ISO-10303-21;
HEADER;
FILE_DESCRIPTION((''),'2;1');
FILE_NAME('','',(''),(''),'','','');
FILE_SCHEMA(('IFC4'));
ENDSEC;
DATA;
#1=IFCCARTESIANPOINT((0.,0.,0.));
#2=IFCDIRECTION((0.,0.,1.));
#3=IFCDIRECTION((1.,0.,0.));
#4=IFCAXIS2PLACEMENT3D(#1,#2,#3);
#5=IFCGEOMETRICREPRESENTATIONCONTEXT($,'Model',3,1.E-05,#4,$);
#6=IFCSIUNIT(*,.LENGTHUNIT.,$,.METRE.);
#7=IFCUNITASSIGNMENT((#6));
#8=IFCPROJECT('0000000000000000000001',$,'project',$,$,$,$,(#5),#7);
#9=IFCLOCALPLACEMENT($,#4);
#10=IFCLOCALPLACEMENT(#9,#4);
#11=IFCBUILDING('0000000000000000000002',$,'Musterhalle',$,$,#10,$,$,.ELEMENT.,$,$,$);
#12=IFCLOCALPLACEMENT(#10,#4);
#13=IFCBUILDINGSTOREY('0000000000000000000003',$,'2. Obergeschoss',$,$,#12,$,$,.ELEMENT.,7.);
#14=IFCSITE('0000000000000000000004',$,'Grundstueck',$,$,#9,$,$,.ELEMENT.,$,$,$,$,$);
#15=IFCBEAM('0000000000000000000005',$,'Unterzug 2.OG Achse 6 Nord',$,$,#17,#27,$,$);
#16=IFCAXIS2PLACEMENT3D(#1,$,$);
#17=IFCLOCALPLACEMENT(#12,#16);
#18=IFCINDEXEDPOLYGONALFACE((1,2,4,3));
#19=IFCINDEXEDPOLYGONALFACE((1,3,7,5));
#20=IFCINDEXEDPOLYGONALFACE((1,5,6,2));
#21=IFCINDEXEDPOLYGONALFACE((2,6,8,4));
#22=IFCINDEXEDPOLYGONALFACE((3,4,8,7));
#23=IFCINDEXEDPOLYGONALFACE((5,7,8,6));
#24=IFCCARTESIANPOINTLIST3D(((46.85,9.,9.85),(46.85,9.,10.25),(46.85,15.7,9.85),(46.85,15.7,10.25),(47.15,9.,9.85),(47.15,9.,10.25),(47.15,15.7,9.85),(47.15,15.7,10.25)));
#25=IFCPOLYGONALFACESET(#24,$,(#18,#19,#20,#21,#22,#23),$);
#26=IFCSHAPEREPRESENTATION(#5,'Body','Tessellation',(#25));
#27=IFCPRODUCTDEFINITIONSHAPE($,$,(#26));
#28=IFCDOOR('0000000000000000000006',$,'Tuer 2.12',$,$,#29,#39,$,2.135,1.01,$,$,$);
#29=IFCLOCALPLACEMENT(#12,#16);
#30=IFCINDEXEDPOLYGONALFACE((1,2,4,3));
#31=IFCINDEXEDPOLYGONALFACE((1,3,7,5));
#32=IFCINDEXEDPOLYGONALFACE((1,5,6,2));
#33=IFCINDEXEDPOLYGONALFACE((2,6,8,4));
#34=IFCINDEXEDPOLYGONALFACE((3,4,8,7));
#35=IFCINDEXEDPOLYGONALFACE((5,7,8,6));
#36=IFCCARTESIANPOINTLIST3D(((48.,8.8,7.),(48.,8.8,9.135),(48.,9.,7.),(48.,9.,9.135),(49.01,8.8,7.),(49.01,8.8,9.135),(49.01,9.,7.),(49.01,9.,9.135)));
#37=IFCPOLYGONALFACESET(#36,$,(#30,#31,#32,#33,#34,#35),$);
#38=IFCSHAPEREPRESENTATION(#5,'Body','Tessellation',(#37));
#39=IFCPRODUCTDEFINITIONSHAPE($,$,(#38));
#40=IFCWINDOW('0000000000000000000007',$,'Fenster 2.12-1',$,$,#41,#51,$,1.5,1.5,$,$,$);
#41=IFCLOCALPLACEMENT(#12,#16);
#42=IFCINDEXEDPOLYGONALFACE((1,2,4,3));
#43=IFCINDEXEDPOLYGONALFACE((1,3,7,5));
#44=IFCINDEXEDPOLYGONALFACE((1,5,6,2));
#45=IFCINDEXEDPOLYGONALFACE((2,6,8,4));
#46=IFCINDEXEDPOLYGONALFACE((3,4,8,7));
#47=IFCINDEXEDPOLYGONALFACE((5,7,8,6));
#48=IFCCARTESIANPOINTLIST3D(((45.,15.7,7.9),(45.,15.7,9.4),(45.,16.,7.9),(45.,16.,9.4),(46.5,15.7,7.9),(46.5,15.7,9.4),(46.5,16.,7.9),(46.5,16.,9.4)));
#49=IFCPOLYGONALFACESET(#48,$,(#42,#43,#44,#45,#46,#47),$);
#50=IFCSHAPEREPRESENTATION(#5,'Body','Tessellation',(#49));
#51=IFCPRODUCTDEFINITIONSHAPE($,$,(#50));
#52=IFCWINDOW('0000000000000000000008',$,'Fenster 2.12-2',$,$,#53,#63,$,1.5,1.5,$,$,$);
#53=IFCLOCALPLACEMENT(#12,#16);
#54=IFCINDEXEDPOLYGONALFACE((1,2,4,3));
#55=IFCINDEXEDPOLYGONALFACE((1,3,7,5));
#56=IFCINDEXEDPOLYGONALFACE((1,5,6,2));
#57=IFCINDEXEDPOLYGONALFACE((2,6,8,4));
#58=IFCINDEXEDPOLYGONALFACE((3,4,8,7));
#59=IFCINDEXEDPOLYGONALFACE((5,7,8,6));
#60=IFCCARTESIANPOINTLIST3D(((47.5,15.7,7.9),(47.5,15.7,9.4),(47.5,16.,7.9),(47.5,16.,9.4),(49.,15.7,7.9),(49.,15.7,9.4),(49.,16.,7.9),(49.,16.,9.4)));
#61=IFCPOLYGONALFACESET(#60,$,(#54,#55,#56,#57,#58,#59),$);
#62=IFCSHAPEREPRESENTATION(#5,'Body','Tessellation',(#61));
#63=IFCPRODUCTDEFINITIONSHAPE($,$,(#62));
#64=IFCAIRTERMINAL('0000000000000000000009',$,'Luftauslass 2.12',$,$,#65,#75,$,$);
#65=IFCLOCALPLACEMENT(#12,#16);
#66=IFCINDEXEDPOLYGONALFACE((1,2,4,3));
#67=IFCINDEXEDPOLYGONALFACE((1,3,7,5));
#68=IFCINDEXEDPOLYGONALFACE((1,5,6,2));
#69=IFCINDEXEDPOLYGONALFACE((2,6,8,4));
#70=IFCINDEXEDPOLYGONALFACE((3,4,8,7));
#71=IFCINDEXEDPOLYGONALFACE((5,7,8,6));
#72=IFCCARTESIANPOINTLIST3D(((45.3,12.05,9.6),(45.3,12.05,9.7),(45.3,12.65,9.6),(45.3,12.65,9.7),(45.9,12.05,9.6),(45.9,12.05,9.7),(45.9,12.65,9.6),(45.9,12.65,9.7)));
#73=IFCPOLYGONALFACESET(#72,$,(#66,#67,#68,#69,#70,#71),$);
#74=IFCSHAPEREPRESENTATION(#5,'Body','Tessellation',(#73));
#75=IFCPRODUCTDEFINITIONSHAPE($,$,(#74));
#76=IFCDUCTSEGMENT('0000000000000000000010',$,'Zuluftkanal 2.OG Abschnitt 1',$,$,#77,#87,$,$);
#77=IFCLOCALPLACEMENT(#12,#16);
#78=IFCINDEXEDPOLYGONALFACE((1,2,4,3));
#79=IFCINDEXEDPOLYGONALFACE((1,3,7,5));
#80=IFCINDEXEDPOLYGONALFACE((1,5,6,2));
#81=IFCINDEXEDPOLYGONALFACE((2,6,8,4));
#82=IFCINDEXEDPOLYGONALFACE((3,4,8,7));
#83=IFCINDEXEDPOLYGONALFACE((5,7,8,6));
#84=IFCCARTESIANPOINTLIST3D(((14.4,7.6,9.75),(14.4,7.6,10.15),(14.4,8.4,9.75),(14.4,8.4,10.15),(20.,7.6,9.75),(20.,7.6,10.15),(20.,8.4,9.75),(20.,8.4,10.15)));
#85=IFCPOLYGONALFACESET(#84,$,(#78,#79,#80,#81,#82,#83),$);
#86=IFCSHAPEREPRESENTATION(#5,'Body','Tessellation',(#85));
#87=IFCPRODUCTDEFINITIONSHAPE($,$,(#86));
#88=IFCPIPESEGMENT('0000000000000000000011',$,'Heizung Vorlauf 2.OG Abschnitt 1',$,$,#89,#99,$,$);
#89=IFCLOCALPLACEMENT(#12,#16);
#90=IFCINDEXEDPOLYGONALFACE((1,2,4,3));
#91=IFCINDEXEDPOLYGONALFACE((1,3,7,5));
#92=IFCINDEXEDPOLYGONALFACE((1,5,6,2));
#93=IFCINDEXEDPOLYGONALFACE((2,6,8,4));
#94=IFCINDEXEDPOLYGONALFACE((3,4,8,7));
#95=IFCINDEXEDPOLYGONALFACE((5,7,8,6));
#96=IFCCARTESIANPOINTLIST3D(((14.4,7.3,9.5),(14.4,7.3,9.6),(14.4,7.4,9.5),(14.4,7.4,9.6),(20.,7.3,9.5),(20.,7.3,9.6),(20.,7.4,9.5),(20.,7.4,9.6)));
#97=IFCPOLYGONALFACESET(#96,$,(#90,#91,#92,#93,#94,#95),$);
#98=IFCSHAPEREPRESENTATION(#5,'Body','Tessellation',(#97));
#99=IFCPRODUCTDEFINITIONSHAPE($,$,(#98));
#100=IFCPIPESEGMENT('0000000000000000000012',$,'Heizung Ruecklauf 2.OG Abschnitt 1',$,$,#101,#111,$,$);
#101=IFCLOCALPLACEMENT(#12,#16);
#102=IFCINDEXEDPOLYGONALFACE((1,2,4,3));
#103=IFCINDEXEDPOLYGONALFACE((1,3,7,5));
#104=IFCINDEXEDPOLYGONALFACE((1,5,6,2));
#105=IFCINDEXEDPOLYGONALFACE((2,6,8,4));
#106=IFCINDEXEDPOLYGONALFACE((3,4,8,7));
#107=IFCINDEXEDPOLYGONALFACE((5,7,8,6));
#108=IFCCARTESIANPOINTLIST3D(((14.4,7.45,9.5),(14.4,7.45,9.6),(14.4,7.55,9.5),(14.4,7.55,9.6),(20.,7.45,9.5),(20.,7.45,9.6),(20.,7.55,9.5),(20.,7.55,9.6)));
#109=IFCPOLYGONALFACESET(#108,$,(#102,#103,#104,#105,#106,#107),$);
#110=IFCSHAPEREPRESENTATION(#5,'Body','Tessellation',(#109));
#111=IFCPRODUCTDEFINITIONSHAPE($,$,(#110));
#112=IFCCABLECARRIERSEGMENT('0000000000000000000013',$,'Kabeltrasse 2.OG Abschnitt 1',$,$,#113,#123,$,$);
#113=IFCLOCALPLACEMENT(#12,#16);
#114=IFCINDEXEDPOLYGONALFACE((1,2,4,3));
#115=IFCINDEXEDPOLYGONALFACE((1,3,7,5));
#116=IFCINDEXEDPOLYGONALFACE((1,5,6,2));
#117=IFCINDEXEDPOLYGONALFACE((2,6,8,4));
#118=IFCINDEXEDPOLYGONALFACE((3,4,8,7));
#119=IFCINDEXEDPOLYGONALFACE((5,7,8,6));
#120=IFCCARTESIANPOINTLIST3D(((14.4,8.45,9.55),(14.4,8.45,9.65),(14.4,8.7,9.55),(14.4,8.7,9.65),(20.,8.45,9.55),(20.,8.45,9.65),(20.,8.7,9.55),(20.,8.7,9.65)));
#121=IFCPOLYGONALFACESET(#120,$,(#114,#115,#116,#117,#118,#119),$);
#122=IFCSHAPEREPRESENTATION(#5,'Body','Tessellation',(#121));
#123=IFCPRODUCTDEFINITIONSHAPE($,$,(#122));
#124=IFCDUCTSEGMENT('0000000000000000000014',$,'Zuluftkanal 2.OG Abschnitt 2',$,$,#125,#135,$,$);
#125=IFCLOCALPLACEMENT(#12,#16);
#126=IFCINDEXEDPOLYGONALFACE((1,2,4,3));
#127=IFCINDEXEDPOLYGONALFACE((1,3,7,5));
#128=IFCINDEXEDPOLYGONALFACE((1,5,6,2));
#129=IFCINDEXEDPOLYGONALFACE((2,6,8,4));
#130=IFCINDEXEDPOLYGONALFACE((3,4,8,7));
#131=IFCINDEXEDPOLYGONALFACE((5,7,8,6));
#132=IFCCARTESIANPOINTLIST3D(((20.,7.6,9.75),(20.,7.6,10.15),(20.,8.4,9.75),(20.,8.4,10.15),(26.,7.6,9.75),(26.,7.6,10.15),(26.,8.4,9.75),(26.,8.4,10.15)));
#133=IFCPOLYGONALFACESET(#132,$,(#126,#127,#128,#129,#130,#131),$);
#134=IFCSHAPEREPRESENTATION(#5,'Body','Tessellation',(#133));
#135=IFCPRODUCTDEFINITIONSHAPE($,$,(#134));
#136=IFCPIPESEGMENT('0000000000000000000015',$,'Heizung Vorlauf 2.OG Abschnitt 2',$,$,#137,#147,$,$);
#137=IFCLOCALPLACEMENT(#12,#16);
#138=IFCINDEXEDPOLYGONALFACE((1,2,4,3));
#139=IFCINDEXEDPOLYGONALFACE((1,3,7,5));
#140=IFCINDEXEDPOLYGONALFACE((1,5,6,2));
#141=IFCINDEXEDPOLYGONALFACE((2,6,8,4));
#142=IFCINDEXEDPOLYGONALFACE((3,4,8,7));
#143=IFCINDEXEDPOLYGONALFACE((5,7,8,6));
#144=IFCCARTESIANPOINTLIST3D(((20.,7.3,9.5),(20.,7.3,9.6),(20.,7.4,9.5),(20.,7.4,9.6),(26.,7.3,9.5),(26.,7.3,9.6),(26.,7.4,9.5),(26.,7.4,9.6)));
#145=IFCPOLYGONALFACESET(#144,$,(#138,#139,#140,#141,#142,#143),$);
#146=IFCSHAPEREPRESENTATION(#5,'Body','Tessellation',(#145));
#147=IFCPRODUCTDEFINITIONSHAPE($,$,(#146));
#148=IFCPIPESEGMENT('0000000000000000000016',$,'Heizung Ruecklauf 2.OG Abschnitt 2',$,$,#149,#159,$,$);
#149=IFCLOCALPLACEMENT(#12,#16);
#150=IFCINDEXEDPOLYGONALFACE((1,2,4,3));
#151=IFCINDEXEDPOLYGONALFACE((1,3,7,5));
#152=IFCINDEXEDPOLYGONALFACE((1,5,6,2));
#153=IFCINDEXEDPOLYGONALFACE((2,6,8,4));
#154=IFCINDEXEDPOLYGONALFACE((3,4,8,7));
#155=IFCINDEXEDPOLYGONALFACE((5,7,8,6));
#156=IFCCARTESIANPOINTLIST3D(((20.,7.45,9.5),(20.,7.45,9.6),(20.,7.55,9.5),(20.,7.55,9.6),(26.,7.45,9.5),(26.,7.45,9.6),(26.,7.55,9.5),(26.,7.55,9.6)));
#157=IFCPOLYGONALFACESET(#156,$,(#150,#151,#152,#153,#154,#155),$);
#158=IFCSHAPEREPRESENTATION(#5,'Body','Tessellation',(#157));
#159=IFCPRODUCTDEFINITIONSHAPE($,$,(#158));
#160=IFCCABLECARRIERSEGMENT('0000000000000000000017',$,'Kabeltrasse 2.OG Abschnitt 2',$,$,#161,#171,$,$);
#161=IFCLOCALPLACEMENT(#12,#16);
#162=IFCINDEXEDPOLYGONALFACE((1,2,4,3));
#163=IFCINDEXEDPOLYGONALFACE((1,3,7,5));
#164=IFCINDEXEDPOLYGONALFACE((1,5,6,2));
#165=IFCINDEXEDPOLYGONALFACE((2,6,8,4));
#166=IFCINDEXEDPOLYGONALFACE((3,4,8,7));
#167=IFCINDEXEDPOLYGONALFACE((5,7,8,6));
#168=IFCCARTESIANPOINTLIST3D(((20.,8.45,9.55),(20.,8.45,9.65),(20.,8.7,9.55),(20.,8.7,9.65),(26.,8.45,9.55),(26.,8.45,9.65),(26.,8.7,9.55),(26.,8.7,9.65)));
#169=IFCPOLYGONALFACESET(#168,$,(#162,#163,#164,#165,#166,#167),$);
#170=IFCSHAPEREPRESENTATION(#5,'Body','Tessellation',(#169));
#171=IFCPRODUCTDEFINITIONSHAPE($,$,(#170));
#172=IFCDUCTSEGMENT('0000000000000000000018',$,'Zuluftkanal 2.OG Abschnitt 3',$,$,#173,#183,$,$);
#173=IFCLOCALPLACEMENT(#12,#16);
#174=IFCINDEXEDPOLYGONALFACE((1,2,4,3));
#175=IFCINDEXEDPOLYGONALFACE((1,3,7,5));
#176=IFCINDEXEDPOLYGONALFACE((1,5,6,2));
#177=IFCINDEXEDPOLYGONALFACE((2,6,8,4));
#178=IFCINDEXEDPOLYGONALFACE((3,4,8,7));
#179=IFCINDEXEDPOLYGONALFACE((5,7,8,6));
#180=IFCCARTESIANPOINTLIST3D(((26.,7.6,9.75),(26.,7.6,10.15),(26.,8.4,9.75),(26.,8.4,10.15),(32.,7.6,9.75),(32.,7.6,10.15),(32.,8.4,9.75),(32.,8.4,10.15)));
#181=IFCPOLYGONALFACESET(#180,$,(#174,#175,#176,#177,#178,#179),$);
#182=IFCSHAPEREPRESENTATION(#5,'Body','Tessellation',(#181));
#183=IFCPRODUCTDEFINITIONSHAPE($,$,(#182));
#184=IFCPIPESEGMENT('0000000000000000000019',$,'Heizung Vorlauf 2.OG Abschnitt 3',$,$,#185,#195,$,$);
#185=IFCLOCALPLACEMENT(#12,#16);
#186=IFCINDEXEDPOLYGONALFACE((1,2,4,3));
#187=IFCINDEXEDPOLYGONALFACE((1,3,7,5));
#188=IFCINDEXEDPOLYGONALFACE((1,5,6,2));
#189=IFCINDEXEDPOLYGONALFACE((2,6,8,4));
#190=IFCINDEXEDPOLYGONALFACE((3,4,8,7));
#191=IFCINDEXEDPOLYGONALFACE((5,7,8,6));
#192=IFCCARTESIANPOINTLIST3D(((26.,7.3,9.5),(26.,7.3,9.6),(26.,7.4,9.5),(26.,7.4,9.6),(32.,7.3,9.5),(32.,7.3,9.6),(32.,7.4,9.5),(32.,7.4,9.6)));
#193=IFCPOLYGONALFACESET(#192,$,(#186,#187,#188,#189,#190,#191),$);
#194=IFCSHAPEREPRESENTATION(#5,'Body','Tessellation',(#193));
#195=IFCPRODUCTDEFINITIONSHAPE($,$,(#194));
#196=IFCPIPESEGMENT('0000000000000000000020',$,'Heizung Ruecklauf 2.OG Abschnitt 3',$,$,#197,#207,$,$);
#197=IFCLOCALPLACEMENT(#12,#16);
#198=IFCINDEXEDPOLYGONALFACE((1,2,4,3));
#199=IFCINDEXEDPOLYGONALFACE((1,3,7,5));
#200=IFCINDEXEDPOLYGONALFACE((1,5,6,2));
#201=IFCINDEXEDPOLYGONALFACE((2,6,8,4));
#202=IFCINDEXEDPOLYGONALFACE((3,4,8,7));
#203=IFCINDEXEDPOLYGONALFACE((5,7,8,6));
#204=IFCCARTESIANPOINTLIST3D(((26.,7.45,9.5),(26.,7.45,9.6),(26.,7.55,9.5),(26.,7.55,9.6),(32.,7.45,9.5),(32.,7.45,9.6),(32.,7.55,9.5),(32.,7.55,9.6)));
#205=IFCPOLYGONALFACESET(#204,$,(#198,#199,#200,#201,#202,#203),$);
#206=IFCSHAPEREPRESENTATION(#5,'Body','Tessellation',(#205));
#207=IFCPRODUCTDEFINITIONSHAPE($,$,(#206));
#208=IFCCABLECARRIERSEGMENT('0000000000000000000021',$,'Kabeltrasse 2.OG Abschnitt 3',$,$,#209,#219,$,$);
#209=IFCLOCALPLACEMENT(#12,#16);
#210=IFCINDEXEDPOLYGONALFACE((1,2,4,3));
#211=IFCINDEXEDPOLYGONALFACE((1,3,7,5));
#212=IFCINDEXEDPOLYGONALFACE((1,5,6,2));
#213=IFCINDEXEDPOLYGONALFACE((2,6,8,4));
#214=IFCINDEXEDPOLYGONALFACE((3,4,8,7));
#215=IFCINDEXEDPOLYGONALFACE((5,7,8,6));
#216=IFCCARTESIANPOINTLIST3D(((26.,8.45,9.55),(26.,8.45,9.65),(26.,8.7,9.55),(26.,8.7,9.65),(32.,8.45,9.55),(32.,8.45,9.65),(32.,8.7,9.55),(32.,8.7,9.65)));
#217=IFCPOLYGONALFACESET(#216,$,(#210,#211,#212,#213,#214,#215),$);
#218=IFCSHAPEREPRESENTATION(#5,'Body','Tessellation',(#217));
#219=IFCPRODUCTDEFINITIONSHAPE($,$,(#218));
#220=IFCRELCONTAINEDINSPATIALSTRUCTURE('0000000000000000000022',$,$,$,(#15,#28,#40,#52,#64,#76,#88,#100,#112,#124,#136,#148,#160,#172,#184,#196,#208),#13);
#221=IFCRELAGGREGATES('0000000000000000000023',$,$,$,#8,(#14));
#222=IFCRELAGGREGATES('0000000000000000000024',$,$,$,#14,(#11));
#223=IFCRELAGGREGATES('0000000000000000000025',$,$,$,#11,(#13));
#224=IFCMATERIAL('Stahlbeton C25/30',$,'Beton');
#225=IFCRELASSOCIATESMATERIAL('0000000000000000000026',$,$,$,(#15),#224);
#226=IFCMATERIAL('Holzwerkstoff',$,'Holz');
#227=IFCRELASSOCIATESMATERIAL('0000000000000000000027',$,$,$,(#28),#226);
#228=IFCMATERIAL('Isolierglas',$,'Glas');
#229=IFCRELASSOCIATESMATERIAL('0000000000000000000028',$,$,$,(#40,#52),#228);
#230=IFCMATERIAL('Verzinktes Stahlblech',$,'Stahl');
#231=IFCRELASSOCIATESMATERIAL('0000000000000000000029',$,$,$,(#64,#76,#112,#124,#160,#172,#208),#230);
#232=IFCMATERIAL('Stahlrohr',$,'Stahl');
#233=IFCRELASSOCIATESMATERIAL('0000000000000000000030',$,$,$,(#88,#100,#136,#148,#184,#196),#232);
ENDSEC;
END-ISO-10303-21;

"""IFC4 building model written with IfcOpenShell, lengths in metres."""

from ifc_helpers import new_model, si_unit, frame, origin_with_axes, origin_2d, place, context, project, spatial, rectangle, extrude, material, element, save


model = new_model("IFC4")

# Units and contexts
model_context = context("Model", 3, precision=1e-05, world=origin_with_axes())
ifc_project = project(units=[si_unit("LENGTHUNIT", "METRE")], contexts=[model_context])

# Site, building, storey
site_placement = place(None, origin_with_axes())
site = spatial("IfcSite", under=ifc_project, at=site_placement, Name="Grundstueck", CompositionType="ELEMENT")
building_placement = place(site_placement, origin_with_axes())
building = spatial("IfcBuilding", under=site, at=building_placement, Name="Musterhalle", CompositionType="ELEMENT")
storey_placement = place(building_placement, origin_with_axes())
storey = spatial("IfcBuildingStorey", under=building, at=storey_placement, Name="2. Obergeschoss", CompositionType="ELEMENT", Elevation=7.0)

# Beam
ifc_material_1 = material(Name="Stahlbeton C25/30", Category="Beton")
placement = place(storey_placement, origin_with_axes())
element("IfcBeam", 1, at=placement, inside=storey, material=ifc_material_1, Name="Unterzug 2.OG Achse 6 Nord", context=model_context, shape_type="SweptSolid", body=[
    extrude(rectangle(XDim=0.3, YDim=6.7, at=origin_2d()), frame((47.0, 12.35, 9.85), z_axis=(0.0, 0.0, 1.0), x_axis=(1.0, 0.0, 0.0)), (0.0, 0.0, 1.0), 0.4),
])

# Door
ifc_material_2 = material(Name="Holzwerkstoff", Category="Holz")
element("IfcDoor", 2, at=placement, inside=storey, material=ifc_material_2, Name="Tuer 2.12", OverallHeight=2.135, OverallWidth=1.01, context=model_context, shape_type="SweptSolid", body=[
    extrude(rectangle(XDim=1.01, YDim=0.2, at=origin_2d()), frame((48.505, 8.9, 7.0), z_axis=(0.0, 0.0, 1.0), x_axis=(1.0, 0.0, 0.0)), (0.0, 0.0, 1.0), 2.135),
])

# Windows
ifc_material_3 = material(Name="Isolierglas", Category="Glas")
element("IfcWindow", 3, at=placement, inside=storey, material=ifc_material_3, Name="Fenster 2.12-1", OverallHeight=1.5, OverallWidth=1.5, context=model_context, shape_type="SweptSolid", body=[
    extrude(rectangle(XDim=1.5, YDim=0.3, at=origin_2d()), frame((45.75, 15.85, 7.9), z_axis=(0.0, 0.0, 1.0), x_axis=(1.0, 0.0, 0.0)), (0.0, 0.0, 1.0), 1.5),
])
element("IfcWindow", 4, at=placement, inside=storey, material=ifc_material_3, Name="Fenster 2.12-2", OverallHeight=1.5, OverallWidth=1.5, context=model_context, shape_type="SweptSolid", body=[
    extrude(rectangle(XDim=1.5, YDim=0.3, at=origin_2d()), frame((48.25, 15.85, 7.9), z_axis=(0.0, 0.0, 1.0), x_axis=(1.0, 0.0, 0.0)), (0.0, 0.0, 1.0), 1.5),
])

# Air terminal
ifc_material_4 = material(Name="Verzinktes Stahlblech", Category="Stahl")
element("IfcAirTerminal", 5, at=placement, inside=storey, material=ifc_material_4, Name="Luftauslass 2.12", context=model_context, shape_type="SweptSolid", body=[
    extrude(rectangle(XDim=0.6, YDim=0.6, at=origin_2d()), frame((45.6, 12.35, 9.6), z_axis=(0.0, 0.0, 1.0), x_axis=(1.0, 0.0, 0.0)), (0.0, 0.0, 1.0), 0.1),
])

# Duct segment
element("IfcDuctSegment", 6, at=placement, inside=storey, material=ifc_material_4, Name="Zuluftkanal 2.OG Abschnitt 1", context=model_context, shape_type="SweptSolid", body=[
    extrude(rectangle(XDim=5.6, YDim=0.8, at=origin_2d()), frame((17.2, 8.0, 9.75), z_axis=(0.0, 0.0, 1.0), x_axis=(1.0, 0.0, 0.0)), (0.0, 0.0, 1.0), 0.4),
])

# Pipe segments
ifc_material_5 = material(Name="Stahlrohr", Category="Stahl")
element("IfcPipeSegment", 7, at=placement, inside=storey, material=ifc_material_5, Name="Heizung Vorlauf 2.OG Abschnitt 1", context=model_context, shape_type="SweptSolid", body=[
    extrude(rectangle(XDim=5.6, YDim=0.1, at=origin_2d()), frame((17.2, 7.35, 9.5), z_axis=(0.0, 0.0, 1.0), x_axis=(1.0, 0.0, 0.0)), (0.0, 0.0, 1.0), 0.1),
])
element("IfcPipeSegment", 8, at=placement, inside=storey, material=ifc_material_5, Name="Heizung Ruecklauf 2.OG Abschnitt 1", context=model_context, shape_type="SweptSolid", body=[
    extrude(rectangle(XDim=5.6, YDim=0.1, at=origin_2d()), frame((17.2, 7.5, 9.5), z_axis=(0.0, 0.0, 1.0), x_axis=(1.0, 0.0, 0.0)), (0.0, 0.0, 1.0), 0.1),
])

# Cable carrier segment
element("IfcCableCarrierSegment", 9, at=placement, inside=storey, material=ifc_material_4, Name="Kabeltrasse 2.OG Abschnitt 1", context=model_context, shape_type="SweptSolid", body=[
    extrude(rectangle(XDim=5.6, YDim=0.25, at=origin_2d()), frame((17.2, 8.575, 9.55), z_axis=(0.0, 0.0, 1.0), x_axis=(1.0, 0.0, 0.0)), (0.0, 0.0, 1.0), 0.1),
])

# Duct segment
element("IfcDuctSegment", 10, at=placement, inside=storey, material=ifc_material_4, Name="Zuluftkanal 2.OG Abschnitt 2", context=model_context, shape_type="SweptSolid", body=[
    extrude(rectangle(XDim=6.0, YDim=0.8, at=origin_2d()), frame((23.0, 8.0, 9.75), z_axis=(0.0, 0.0, 1.0), x_axis=(1.0, 0.0, 0.0)), (0.0, 0.0, 1.0), 0.4),
])

# Pipe segments
element("IfcPipeSegment", 11, at=placement, inside=storey, material=ifc_material_5, Name="Heizung Vorlauf 2.OG Abschnitt 2", context=model_context, shape_type="SweptSolid", body=[
    extrude(rectangle(XDim=6.0, YDim=0.1, at=origin_2d()), frame((23.0, 7.35, 9.5), z_axis=(0.0, 0.0, 1.0), x_axis=(1.0, 0.0, 0.0)), (0.0, 0.0, 1.0), 0.1),
])
element("IfcPipeSegment", 12, at=placement, inside=storey, material=ifc_material_5, Name="Heizung Ruecklauf 2.OG Abschnitt 2", context=model_context, shape_type="SweptSolid", body=[
    extrude(rectangle(XDim=6.0, YDim=0.1, at=origin_2d()), frame((23.0, 7.5, 9.5), z_axis=(0.0, 0.0, 1.0), x_axis=(1.0, 0.0, 0.0)), (0.0, 0.0, 1.0), 0.1),
])

# Cable carrier segment
element("IfcCableCarrierSegment", 13, at=placement, inside=storey, material=ifc_material_4, Name="Kabeltrasse 2.OG Abschnitt 2", context=model_context, shape_type="SweptSolid", body=[
    extrude(rectangle(XDim=6.0, YDim=0.25, at=origin_2d()), frame((23.0, 8.575, 9.55), z_axis=(0.0, 0.0, 1.0), x_axis=(1.0, 0.0, 0.0)), (0.0, 0.0, 1.0), 0.1),
])

# Duct segment
element("IfcDuctSegment", 14, at=placement, inside=storey, material=ifc_material_4, Name="Zuluftkanal 2.OG Abschnitt 3", context=model_context, shape_type="SweptSolid", body=[
    extrude(rectangle(XDim=6.0, YDim=0.8, at=origin_2d()), frame((29.0, 8.0, 9.75), z_axis=(0.0, 0.0, 1.0), x_axis=(1.0, 0.0, 0.0)), (0.0, 0.0, 1.0), 0.4),
])

# Pipe segments
element("IfcPipeSegment", 15, at=placement, inside=storey, material=ifc_material_5, Name="Heizung Vorlauf 2.OG Abschnitt 3", context=model_context, shape_type="SweptSolid", body=[
    extrude(rectangle(XDim=6.0, YDim=0.1, at=origin_2d()), frame((29.0, 7.35, 9.5), z_axis=(0.0, 0.0, 1.0), x_axis=(1.0, 0.0, 0.0)), (0.0, 0.0, 1.0), 0.1),
])
element("IfcPipeSegment", 16, at=placement, inside=storey, material=ifc_material_5, Name="Heizung Ruecklauf 2.OG Abschnitt 3", context=model_context, shape_type="SweptSolid", body=[
    extrude(rectangle(XDim=6.0, YDim=0.1, at=origin_2d()), frame((29.0, 7.5, 9.5), z_axis=(0.0, 0.0, 1.0), x_axis=(1.0, 0.0, 0.0)), (0.0, 0.0, 1.0), 0.1),
])

# Cable carrier segment
element("IfcCableCarrierSegment", 17, at=placement, inside=storey, material=ifc_material_4, Name="Kabeltrasse 2.OG Abschnitt 3", context=model_context, shape_type="SweptSolid", body=[
    extrude(rectangle(XDim=6.0, YDim=0.25, at=origin_2d()), frame((29.0, 8.575, 9.55), z_axis=(0.0, 0.0, 1.0), x_axis=(1.0, 0.0, 0.0)), (0.0, 0.0, 1.0), 0.1),
])

save(model, "model.ifc")
